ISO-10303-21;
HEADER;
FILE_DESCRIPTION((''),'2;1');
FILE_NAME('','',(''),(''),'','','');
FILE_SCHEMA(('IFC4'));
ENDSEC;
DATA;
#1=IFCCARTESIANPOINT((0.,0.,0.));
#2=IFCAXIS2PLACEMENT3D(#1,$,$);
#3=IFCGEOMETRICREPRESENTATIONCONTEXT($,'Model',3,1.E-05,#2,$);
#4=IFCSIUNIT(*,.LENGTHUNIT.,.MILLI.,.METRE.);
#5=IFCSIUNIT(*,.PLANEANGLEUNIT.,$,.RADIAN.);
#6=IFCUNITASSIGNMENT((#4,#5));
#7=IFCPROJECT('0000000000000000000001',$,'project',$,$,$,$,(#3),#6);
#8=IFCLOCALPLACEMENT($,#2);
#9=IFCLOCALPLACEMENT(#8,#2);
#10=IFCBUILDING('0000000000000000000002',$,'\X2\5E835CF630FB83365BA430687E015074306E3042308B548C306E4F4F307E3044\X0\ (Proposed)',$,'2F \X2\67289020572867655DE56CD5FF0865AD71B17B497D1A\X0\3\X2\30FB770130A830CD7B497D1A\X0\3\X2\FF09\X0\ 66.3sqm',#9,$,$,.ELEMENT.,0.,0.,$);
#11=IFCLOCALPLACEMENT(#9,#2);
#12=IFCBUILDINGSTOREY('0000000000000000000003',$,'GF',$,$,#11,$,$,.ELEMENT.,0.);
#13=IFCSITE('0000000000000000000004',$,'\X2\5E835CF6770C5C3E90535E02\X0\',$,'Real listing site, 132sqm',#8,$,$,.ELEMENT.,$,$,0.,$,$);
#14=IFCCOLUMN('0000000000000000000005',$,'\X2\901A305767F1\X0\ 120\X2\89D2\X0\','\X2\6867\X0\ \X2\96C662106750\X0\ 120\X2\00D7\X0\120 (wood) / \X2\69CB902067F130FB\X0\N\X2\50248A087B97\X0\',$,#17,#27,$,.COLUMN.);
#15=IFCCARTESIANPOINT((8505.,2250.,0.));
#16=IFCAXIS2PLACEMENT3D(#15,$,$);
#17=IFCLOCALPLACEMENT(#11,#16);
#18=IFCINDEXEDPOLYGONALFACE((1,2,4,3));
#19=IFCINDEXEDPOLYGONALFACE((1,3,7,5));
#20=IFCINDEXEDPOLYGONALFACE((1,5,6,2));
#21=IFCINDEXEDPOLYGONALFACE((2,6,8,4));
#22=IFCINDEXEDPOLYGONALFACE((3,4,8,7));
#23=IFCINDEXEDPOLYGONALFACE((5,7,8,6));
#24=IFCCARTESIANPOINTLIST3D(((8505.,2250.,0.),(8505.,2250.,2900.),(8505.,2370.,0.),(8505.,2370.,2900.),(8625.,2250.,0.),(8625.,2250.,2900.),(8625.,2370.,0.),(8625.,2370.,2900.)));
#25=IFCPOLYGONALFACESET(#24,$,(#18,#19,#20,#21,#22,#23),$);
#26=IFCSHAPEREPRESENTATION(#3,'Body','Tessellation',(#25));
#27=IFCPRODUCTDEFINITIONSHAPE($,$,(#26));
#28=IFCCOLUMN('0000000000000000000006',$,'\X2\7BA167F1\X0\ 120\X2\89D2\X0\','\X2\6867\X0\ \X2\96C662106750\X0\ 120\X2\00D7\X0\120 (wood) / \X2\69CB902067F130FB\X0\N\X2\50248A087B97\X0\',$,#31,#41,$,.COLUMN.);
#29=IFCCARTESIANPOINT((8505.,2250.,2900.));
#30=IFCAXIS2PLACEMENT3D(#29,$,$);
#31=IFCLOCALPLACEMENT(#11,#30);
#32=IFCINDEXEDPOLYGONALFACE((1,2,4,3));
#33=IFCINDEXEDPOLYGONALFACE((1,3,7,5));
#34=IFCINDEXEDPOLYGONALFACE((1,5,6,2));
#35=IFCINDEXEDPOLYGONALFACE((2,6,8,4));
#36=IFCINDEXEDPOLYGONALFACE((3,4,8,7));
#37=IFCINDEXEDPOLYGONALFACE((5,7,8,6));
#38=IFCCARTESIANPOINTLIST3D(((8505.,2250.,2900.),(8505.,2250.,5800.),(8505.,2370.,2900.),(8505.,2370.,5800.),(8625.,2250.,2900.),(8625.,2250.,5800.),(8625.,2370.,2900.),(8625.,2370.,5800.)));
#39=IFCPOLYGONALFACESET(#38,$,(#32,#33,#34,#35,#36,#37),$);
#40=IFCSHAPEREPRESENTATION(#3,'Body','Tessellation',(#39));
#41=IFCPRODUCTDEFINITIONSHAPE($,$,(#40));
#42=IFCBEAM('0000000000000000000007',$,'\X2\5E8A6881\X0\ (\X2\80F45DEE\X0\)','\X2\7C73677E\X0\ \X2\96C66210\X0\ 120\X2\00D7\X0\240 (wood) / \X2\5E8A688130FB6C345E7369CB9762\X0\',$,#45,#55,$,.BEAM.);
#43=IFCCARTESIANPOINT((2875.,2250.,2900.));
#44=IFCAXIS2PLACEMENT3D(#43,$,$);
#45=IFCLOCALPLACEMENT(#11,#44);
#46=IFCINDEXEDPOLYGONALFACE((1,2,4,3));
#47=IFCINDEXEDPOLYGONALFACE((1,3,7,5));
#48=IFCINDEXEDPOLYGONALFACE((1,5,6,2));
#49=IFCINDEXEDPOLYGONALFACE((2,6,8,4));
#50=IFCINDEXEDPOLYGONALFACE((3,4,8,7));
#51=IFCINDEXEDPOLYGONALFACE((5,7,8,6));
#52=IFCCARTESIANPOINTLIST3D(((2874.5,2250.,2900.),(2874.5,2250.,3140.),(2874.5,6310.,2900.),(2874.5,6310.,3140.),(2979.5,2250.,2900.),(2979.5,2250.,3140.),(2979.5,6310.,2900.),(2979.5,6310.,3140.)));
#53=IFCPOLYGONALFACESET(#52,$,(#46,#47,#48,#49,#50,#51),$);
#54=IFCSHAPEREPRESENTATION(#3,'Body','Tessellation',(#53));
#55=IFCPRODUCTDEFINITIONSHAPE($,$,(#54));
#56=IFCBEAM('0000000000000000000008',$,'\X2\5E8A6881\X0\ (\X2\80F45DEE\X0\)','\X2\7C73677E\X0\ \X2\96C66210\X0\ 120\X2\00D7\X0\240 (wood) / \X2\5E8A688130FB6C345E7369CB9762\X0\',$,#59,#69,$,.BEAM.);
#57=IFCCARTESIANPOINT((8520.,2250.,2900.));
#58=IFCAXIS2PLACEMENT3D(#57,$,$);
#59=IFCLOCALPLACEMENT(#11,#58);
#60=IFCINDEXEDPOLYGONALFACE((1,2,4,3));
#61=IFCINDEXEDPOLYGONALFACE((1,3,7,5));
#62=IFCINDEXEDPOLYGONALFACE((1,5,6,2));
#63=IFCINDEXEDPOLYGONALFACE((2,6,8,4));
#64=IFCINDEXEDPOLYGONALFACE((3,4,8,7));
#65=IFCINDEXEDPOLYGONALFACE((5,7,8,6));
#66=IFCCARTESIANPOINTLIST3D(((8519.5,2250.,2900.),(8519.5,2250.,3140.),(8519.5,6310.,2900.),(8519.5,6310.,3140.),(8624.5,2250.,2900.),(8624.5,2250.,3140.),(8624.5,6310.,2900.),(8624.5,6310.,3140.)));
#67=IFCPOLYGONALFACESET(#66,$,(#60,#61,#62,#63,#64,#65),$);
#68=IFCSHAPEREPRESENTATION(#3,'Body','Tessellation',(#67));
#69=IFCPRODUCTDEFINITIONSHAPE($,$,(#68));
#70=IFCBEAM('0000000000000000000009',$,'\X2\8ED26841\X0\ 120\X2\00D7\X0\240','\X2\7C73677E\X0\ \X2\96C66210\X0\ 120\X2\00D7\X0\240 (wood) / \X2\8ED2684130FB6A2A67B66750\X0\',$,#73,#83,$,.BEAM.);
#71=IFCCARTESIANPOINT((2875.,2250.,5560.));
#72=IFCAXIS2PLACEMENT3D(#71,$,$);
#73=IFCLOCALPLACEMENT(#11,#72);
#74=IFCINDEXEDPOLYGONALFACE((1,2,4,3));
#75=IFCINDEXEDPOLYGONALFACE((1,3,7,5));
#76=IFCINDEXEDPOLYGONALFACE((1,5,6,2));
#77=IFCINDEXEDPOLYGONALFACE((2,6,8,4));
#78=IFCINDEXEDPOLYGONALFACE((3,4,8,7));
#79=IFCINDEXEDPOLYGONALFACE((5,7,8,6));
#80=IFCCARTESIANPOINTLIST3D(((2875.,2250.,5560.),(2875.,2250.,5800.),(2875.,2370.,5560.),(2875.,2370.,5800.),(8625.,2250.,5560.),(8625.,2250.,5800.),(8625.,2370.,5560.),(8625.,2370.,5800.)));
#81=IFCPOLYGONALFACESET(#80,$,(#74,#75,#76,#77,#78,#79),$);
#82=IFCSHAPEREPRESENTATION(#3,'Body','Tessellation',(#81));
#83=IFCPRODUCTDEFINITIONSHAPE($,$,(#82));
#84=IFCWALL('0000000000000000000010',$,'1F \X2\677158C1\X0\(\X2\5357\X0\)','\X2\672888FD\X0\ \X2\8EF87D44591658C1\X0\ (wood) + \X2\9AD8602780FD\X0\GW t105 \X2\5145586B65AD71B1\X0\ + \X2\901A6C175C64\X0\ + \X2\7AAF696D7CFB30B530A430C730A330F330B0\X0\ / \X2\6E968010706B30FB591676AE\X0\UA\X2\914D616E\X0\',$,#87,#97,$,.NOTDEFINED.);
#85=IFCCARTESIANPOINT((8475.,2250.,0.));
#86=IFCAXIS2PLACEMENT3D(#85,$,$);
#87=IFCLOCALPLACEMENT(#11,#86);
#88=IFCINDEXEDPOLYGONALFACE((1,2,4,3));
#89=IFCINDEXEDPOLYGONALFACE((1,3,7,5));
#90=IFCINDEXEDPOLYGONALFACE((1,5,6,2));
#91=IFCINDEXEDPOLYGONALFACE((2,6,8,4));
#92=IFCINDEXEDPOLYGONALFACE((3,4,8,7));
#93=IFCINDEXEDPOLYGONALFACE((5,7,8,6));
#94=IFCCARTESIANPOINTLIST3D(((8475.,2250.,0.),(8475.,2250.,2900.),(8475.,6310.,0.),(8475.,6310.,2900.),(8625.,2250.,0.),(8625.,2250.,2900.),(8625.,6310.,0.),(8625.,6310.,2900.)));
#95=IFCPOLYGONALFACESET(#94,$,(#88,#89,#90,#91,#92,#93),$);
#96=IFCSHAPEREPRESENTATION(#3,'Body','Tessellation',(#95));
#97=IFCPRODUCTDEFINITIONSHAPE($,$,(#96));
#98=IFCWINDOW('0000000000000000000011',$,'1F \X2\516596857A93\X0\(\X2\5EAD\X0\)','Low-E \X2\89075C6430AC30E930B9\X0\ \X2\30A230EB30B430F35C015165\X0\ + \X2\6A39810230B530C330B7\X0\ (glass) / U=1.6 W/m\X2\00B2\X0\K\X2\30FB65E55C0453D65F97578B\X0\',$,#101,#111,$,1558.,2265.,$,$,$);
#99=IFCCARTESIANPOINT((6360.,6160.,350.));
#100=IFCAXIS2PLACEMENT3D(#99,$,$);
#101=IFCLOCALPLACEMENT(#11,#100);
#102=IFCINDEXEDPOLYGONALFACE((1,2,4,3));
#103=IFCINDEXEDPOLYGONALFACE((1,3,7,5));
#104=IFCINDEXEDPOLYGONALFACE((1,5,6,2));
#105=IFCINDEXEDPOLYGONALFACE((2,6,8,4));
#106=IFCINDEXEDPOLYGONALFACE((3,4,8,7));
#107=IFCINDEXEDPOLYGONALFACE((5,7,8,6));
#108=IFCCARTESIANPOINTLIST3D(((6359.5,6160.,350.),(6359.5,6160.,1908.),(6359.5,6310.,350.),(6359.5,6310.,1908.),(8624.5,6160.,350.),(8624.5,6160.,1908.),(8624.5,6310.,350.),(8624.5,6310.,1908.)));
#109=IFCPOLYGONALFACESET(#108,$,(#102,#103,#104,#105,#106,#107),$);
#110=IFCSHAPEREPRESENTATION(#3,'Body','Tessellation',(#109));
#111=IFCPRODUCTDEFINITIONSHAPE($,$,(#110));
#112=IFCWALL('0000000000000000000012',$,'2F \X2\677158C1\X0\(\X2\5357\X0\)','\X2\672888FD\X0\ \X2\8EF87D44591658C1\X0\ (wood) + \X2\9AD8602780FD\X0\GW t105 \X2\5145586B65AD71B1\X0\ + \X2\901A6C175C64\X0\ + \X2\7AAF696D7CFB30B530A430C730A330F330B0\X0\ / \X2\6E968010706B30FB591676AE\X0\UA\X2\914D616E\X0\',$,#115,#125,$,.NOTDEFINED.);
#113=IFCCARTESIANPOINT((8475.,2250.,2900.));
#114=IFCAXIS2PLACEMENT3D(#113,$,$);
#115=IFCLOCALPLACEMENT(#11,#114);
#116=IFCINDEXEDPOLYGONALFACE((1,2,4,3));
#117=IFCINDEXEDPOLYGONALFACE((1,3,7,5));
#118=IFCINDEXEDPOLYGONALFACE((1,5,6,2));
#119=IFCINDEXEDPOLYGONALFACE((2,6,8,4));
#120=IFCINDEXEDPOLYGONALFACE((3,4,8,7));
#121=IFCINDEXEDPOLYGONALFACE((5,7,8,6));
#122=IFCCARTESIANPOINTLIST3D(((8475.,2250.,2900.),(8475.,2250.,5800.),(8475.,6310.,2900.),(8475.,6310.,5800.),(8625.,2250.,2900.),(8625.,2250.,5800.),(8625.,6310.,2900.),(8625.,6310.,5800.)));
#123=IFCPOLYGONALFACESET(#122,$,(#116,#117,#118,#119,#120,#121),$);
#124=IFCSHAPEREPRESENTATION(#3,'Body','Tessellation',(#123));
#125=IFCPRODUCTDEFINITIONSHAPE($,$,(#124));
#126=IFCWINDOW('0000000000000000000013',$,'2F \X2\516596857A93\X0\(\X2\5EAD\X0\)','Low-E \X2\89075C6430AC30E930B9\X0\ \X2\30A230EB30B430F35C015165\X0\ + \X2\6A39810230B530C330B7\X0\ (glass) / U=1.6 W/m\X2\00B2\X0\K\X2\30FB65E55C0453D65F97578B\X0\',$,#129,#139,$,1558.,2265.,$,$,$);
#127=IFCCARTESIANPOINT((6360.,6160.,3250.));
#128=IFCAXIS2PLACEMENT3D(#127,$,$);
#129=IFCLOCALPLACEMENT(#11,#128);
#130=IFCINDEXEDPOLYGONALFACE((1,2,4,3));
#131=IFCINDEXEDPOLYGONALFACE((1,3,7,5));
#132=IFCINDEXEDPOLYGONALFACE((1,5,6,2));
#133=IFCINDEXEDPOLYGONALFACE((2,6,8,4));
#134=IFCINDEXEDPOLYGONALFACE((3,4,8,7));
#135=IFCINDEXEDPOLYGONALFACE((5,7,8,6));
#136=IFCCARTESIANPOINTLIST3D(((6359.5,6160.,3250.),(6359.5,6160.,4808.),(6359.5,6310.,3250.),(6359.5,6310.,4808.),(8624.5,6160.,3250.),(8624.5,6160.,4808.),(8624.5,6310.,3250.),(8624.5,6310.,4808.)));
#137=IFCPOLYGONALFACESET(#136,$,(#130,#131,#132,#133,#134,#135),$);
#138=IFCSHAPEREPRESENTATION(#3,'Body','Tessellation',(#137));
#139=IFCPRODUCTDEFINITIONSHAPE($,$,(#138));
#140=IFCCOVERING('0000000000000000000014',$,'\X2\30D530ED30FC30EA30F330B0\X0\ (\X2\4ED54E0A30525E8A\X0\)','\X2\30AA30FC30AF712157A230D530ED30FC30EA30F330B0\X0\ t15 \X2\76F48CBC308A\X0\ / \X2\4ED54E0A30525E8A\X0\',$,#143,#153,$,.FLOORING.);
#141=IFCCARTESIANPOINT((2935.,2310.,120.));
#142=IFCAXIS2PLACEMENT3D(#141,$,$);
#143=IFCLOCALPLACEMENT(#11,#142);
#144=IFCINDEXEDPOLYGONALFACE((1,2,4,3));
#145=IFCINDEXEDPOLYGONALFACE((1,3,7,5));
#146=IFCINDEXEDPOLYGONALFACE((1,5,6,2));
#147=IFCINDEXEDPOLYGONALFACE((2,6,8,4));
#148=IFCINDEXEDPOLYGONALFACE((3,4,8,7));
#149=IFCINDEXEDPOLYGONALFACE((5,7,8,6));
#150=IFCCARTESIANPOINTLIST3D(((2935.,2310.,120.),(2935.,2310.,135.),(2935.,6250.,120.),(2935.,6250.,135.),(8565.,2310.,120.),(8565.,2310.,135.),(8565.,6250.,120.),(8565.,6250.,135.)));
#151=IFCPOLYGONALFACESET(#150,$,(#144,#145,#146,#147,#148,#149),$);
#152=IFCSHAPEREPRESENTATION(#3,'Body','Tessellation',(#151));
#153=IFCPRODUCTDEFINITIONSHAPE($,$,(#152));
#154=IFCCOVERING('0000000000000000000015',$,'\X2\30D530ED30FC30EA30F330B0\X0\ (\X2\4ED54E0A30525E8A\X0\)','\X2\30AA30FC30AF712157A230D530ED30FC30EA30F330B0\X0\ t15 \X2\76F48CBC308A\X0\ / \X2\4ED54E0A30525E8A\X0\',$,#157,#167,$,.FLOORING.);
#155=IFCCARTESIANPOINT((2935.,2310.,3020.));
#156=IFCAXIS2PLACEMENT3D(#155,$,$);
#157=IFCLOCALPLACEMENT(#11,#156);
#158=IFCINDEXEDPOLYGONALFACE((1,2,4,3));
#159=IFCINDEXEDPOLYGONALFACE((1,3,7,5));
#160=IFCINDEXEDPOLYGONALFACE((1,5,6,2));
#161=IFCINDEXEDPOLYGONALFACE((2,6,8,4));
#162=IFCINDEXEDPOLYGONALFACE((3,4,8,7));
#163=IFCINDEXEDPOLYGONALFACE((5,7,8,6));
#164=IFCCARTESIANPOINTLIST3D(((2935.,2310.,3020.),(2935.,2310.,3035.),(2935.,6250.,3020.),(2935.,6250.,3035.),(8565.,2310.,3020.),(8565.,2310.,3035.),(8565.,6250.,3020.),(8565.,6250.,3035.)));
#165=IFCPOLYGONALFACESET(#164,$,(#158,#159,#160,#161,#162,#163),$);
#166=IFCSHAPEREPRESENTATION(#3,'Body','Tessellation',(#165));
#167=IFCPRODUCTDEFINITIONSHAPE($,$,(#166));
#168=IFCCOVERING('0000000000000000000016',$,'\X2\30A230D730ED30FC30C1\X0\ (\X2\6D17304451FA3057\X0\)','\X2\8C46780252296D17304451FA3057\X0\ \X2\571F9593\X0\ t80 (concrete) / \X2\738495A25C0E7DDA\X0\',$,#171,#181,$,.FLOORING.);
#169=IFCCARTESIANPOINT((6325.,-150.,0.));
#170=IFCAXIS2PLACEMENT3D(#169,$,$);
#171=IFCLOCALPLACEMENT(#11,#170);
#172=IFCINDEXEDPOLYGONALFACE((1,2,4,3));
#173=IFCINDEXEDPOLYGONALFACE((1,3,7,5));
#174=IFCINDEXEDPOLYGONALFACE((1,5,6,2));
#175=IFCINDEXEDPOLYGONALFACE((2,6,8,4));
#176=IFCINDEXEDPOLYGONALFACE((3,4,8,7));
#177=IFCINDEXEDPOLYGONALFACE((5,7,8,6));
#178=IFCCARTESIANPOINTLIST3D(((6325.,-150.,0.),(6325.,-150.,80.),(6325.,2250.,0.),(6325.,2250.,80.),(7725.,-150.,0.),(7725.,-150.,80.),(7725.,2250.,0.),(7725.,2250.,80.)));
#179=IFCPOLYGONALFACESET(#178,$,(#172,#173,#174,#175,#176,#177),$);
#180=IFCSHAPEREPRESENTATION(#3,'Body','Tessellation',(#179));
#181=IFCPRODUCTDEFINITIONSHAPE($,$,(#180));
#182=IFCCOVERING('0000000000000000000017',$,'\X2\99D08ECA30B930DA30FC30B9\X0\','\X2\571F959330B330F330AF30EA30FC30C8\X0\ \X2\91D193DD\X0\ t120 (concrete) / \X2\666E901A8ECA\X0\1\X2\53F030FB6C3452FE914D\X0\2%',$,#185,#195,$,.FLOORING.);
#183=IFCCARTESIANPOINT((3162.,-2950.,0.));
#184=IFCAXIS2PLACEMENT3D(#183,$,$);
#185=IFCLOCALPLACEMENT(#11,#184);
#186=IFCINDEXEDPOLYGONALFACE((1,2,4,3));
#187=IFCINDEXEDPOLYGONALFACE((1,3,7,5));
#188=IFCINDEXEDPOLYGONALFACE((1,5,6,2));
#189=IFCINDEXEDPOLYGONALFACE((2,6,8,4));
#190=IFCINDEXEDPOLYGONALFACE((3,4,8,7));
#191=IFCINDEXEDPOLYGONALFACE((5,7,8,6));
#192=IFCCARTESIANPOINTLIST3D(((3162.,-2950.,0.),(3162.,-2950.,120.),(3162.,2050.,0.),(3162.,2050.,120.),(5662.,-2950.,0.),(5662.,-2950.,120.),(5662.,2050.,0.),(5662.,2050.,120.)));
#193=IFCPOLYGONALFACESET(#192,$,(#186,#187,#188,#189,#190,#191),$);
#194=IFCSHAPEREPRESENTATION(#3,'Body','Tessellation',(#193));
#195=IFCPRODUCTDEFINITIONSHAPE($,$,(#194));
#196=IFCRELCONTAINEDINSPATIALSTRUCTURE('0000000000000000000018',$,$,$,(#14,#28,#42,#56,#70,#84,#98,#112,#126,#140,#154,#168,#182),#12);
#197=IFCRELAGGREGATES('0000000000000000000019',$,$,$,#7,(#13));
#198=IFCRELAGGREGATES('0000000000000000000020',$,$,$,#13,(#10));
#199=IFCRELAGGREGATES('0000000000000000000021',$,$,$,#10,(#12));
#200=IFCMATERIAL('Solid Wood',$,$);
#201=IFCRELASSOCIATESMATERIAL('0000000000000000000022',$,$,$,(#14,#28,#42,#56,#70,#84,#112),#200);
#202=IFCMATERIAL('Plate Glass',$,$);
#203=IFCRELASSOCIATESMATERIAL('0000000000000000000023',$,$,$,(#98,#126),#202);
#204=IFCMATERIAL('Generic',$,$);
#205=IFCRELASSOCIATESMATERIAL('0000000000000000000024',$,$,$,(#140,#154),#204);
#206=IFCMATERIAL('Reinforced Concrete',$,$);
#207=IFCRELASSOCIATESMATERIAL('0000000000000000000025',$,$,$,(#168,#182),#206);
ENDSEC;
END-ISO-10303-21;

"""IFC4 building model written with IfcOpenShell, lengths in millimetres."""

from ifc_helpers import new_model, si_unit, frame, frame_2d, origin, place, context, project, spatial, rectangle, extrude, material, element, fill, save


model = new_model("IFC4")

# Units and contexts
model_context = context("Model", 3, precision=1e-05, world=origin())
ifc_project = project(units=[si_unit("LENGTHUNIT", "METRE", prefix="MILLI"), si_unit("PLANEANGLEUNIT", "RADIAN")], contexts=[model_context])

# Site, building, storey
site_placement = place(None, origin())
site = spatial("IfcSite", under=ifc_project, at=site_placement, Name="広島県尾道市", ObjectType="Real listing site, 132sqm", CompositionType="ELEMENT", RefElevation=0.0)
building_placement = place(site_placement, origin())
building = spatial("IfcBuilding", under=site, at=building_placement, Name="広島・茶室と縁側のある和の住まい (Proposed)", ObjectType="2F 木造在来工法（断熱等級3・省エネ等級3） 66.3sqm", CompositionType="ELEMENT", ElevationOfRefHeight=0.0, ElevationOfTerrain=0.0)
storey_placement = place(building_placement, origin())
storey = spatial("IfcBuildingStorey", under=building, at=storey_placement, Name="GF", CompositionType="ELEMENT", Elevation=0.0)

# Columns
ifc_material_1 = material(Name="Solid Wood")
column_1_placement = place(storey_placement, frame((8505.0, 2250.0, 0.0)))
element("IfcColumn", 1, at=column_1_placement, inside=storey, material=ifc_material_1, Name="通し柱 120角", Description="桧 集成材 120×120 (wood) / 構造柱・N値計算", PredefinedType="COLUMN", context=model_context, shape_type="SweptSolid", body=[
    extrude(rectangle(XDim=120.0, YDim=120.0, at=frame_2d((60.0, 60.0))), frame((8505.0, 2250.0, 0.0)), (0.0, 0.0, 1.0), 2900.0),
])
column_2_placement = place(storey_placement, frame((8505.0, 2250.0, 2900.0)))
element("IfcColumn", 2, at=column_2_placement, inside=storey, material=ifc_material_1, Name="管柱 120角", Description="桧 集成材 120×120 (wood) / 構造柱・N値計算", PredefinedType="COLUMN", context=model_context, shape_type="SweptSolid", body=[
    extrude(rectangle(XDim=120.0, YDim=120.0, at=frame_2d((60.0, 60.0))), frame((8505.0, 2250.0, 2900.0)), (0.0, 0.0, 1.0), 2900.0),
])

# Beams
beam_1_placement = place(storey_placement, frame((2875.0, 2250.0, 2900.0)))
element("IfcBeam", 3, at=beam_1_placement, inside=storey, material=ifc_material_1, Name="床梁 (胴差)", Description="米松 集成 120×240 (wood) / 床梁・水平構面", PredefinedType="BEAM", context=model_context, shape_type="SweptSolid", body=[
    extrude(rectangle(XDim=105.0, YDim=4060.0, at=frame_2d((52.0, 2030.0))), frame((2875.0, 2250.0, 2900.0)), (0.0, 0.0, 1.0), 240.0),
])
beam_2_placement = place(storey_placement, frame((8520.0, 2250.0, 2900.0)))
element("IfcBeam", 4, at=beam_2_placement, inside=storey, material=ifc_material_1, Name="床梁 (胴差)", Description="米松 集成 120×240 (wood) / 床梁・水平構面", PredefinedType="BEAM", context=model_context, shape_type="SweptSolid", body=[
    extrude(rectangle(XDim=105.0, YDim=4060.0, at=frame_2d((52.0, 2030.0))), frame((8520.0, 2250.0, 2900.0)), (0.0, 0.0, 1.0), 240.0),
])
beam_3_placement = place(storey_placement, frame((2875.0, 2250.0, 5560.0)))
element("IfcBeam", 5, at=beam_3_placement, inside=storey, material=ifc_material_1, Name="軒桁 120×240", Description="米松 集成 120×240 (wood) / 軒桁・横架材", PredefinedType="BEAM", context=model_context, shape_type="SweptSolid", body=[
    extrude(rectangle(XDim=5750.0, YDim=120.0, at=frame_2d((2875.0, 60.0))), frame((2875.0, 2250.0, 5560.0)), (0.0, 0.0, 1.0), 240.0),
])

# Wall, opening, window
wall_1_placement = place(storey_placement, frame((8475.0, 2250.0, 0.0)))
wall_1 = element("IfcWall", 6, at=wall_1_placement, inside=storey, material=ifc_material_1, Name="1F 東壁(南)", Description="木製 軸組外壁 (wood) + 高性能GW t105 充填断熱 + 通気層 + 窯業系サイディング / 準耐火・外皮UA配慮", PredefinedType="NOTDEFINED", context=model_context, shape_type="SweptSolid", body=[
    extrude(rectangle(XDim=150.0, YDim=4060.0, at=frame_2d((75.0, 2030.0))), frame((8475.0, 2250.0, 0.0)), (0.0, 0.0, 1.0), 2900.0),
])
opening_1_placement = place(storey_placement, frame((6360.0, 6160.0, 350.0)))
opening_1 = element("IfcOpeningElement", 7, at=opening_1_placement, cuts=wall_1, PredefinedType="NOTDEFINED", context=model_context, shape_type="SweptSolid", body=[
    extrude(rectangle(XDim=2265.0, YDim=150.0, at=frame_2d((1132.0, 75.0))), frame((6360.0, 6160.0, 350.0)), (0.0, 0.0, 1.0), 1558.0),
])
ifc_material_2 = material(Name="Plate Glass")
window_1_placement = place(storey_placement, frame((6360.0, 6160.0, 350.0)))
window_1 = element("IfcWindow", 8, at=window_1_placement, inside=storey, material=ifc_material_2, Name="1F 入隅窓(庭)", Description="Low-E 複層ガラス アルゴン封入 + 樹脂サッシ (glass) / U=1.6 W/m²K・日射取得型", OverallHeight=1558.0, OverallWidth=2265.0, context=model_context, shape_type="SweptSolid", body=[
    extrude(rectangle(XDim=2265.0, YDim=150.0, at=frame_2d((1132.0, 75.0))), frame((6360.0, 6160.0, 350.0)), (0.0, 0.0, 1.0), 1558.0),
])
fill(opening_1, window_1)

# Wall, opening, window
wall_2_placement = place(storey_placement, frame((8475.0, 2250.0, 2900.0)))
wall_2 = element("IfcWall", 9, at=wall_2_placement, inside=storey, material=ifc_material_1, Name="2F 東壁(南)", Description="木製 軸組外壁 (wood) + 高性能GW t105 充填断熱 + 通気層 + 窯業系サイディング / 準耐火・外皮UA配慮", PredefinedType="NOTDEFINED", context=model_context, shape_type="SweptSolid", body=[
    extrude(rectangle(XDim=150.0, YDim=4060.0, at=frame_2d((75.0, 2030.0))), frame((8475.0, 2250.0, 2900.0)), (0.0, 0.0, 1.0), 2900.0),
])
opening_2_placement = place(storey_placement, frame((6360.0, 6160.0, 3250.0)))
opening_2 = element("IfcOpeningElement", 10, at=opening_2_placement, cuts=wall_2, PredefinedType="NOTDEFINED", context=model_context, shape_type="SweptSolid", body=[
    extrude(rectangle(XDim=2265.0, YDim=150.0, at=frame_2d((1132.0, 75.0))), frame((6360.0, 6160.0, 3250.0)), (0.0, 0.0, 1.0), 1558.0),
])
window_2_placement = place(storey_placement, frame((6360.0, 6160.0, 3250.0)))
window_2 = element("IfcWindow", 11, at=window_2_placement, inside=storey, material=ifc_material_2, Name="2F 入隅窓(庭)", Description="Low-E 複層ガラス アルゴン封入 + 樹脂サッシ (glass) / U=1.6 W/m²K・日射取得型", OverallHeight=1558.0, OverallWidth=2265.0, context=model_context, shape_type="SweptSolid", body=[
    extrude(rectangle(XDim=2265.0, YDim=150.0, at=frame_2d((1132.0, 75.0))), frame((6360.0, 6160.0, 3250.0)), (0.0, 0.0, 1.0), 1558.0),
])
fill(opening_2, window_2)

# Coverings
ifc_material_3 = material(Name="Generic")
covering_1_placement = place(storey_placement, frame((2935.0, 2310.0, 120.0)))
element("IfcCovering", 12, at=covering_1_placement, inside=storey, material=ifc_material_3, Name="フローリング (仕上げ床)", Description="オーク無垢フローリング t15 直貼り / 仕上げ床", PredefinedType="FLOORING", context=model_context, shape_type="SweptSolid", body=[
    extrude(rectangle(XDim=5630.0, YDim=3940.0, at=frame_2d((2815.0, 1970.0))), frame((2935.0, 2310.0, 120.0)), (0.0, 0.0, 1.0), 15.0),
])
covering_2_placement = place(storey_placement, frame((2935.0, 2310.0, 3020.0)))
element("IfcCovering", 13, at=covering_2_placement, inside=storey, material=ifc_material_3, Name="フローリング (仕上げ床)", Description="オーク無垢フローリング t15 直貼り / 仕上げ床", PredefinedType="FLOORING", context=model_context, shape_type="SweptSolid", body=[
    extrude(rectangle(XDim=5630.0, YDim=3940.0, at=frame_2d((2815.0, 1970.0))), frame((2935.0, 2310.0, 3020.0)), (0.0, 0.0, 1.0), 15.0),
])
ifc_material_4 = material(Name="Reinforced Concrete")
covering_3_placement = place(storey_placement, frame((6325.0, -150.0, 0.0)))
element("IfcCovering", 14, at=covering_3_placement, inside=storey, material=ifc_material_4, Name="アプローチ (洗い出し)", Description="豆砂利洗い出し 土間 t80 (concrete) / 玄関導線", PredefinedType="FLOORING", context=model_context, shape_type="SweptSolid", body=[
    extrude(rectangle(XDim=1400.0, YDim=2400.0, at=frame_2d((700.0, 1200.0))), frame((6325.0, -150.0, 0.0)), (0.0, 0.0, 1.0), 80.0),
])
covering_4_placement = place(storey_placement, frame((3162.0, -2950.0, 0.0)))
element("IfcCovering", 15, at=covering_4_placement, inside=storey, material=ifc_material_4, Name="駐車スペース", Description="土間コンクリート 金鏝 t120 (concrete) / 普通車1台・水勾配2%", PredefinedType="FLOORING", context=model_context, shape_type="SweptSolid", body=[
    extrude(rectangle(XDim=2500.0, YDim=5000.0, at=frame_2d((1250.0, 2500.0))), frame((3162.0, -2950.0, 0.0)), (0.0, 0.0, 1.0), 120.0),
])

save(model, "model.ifc")
